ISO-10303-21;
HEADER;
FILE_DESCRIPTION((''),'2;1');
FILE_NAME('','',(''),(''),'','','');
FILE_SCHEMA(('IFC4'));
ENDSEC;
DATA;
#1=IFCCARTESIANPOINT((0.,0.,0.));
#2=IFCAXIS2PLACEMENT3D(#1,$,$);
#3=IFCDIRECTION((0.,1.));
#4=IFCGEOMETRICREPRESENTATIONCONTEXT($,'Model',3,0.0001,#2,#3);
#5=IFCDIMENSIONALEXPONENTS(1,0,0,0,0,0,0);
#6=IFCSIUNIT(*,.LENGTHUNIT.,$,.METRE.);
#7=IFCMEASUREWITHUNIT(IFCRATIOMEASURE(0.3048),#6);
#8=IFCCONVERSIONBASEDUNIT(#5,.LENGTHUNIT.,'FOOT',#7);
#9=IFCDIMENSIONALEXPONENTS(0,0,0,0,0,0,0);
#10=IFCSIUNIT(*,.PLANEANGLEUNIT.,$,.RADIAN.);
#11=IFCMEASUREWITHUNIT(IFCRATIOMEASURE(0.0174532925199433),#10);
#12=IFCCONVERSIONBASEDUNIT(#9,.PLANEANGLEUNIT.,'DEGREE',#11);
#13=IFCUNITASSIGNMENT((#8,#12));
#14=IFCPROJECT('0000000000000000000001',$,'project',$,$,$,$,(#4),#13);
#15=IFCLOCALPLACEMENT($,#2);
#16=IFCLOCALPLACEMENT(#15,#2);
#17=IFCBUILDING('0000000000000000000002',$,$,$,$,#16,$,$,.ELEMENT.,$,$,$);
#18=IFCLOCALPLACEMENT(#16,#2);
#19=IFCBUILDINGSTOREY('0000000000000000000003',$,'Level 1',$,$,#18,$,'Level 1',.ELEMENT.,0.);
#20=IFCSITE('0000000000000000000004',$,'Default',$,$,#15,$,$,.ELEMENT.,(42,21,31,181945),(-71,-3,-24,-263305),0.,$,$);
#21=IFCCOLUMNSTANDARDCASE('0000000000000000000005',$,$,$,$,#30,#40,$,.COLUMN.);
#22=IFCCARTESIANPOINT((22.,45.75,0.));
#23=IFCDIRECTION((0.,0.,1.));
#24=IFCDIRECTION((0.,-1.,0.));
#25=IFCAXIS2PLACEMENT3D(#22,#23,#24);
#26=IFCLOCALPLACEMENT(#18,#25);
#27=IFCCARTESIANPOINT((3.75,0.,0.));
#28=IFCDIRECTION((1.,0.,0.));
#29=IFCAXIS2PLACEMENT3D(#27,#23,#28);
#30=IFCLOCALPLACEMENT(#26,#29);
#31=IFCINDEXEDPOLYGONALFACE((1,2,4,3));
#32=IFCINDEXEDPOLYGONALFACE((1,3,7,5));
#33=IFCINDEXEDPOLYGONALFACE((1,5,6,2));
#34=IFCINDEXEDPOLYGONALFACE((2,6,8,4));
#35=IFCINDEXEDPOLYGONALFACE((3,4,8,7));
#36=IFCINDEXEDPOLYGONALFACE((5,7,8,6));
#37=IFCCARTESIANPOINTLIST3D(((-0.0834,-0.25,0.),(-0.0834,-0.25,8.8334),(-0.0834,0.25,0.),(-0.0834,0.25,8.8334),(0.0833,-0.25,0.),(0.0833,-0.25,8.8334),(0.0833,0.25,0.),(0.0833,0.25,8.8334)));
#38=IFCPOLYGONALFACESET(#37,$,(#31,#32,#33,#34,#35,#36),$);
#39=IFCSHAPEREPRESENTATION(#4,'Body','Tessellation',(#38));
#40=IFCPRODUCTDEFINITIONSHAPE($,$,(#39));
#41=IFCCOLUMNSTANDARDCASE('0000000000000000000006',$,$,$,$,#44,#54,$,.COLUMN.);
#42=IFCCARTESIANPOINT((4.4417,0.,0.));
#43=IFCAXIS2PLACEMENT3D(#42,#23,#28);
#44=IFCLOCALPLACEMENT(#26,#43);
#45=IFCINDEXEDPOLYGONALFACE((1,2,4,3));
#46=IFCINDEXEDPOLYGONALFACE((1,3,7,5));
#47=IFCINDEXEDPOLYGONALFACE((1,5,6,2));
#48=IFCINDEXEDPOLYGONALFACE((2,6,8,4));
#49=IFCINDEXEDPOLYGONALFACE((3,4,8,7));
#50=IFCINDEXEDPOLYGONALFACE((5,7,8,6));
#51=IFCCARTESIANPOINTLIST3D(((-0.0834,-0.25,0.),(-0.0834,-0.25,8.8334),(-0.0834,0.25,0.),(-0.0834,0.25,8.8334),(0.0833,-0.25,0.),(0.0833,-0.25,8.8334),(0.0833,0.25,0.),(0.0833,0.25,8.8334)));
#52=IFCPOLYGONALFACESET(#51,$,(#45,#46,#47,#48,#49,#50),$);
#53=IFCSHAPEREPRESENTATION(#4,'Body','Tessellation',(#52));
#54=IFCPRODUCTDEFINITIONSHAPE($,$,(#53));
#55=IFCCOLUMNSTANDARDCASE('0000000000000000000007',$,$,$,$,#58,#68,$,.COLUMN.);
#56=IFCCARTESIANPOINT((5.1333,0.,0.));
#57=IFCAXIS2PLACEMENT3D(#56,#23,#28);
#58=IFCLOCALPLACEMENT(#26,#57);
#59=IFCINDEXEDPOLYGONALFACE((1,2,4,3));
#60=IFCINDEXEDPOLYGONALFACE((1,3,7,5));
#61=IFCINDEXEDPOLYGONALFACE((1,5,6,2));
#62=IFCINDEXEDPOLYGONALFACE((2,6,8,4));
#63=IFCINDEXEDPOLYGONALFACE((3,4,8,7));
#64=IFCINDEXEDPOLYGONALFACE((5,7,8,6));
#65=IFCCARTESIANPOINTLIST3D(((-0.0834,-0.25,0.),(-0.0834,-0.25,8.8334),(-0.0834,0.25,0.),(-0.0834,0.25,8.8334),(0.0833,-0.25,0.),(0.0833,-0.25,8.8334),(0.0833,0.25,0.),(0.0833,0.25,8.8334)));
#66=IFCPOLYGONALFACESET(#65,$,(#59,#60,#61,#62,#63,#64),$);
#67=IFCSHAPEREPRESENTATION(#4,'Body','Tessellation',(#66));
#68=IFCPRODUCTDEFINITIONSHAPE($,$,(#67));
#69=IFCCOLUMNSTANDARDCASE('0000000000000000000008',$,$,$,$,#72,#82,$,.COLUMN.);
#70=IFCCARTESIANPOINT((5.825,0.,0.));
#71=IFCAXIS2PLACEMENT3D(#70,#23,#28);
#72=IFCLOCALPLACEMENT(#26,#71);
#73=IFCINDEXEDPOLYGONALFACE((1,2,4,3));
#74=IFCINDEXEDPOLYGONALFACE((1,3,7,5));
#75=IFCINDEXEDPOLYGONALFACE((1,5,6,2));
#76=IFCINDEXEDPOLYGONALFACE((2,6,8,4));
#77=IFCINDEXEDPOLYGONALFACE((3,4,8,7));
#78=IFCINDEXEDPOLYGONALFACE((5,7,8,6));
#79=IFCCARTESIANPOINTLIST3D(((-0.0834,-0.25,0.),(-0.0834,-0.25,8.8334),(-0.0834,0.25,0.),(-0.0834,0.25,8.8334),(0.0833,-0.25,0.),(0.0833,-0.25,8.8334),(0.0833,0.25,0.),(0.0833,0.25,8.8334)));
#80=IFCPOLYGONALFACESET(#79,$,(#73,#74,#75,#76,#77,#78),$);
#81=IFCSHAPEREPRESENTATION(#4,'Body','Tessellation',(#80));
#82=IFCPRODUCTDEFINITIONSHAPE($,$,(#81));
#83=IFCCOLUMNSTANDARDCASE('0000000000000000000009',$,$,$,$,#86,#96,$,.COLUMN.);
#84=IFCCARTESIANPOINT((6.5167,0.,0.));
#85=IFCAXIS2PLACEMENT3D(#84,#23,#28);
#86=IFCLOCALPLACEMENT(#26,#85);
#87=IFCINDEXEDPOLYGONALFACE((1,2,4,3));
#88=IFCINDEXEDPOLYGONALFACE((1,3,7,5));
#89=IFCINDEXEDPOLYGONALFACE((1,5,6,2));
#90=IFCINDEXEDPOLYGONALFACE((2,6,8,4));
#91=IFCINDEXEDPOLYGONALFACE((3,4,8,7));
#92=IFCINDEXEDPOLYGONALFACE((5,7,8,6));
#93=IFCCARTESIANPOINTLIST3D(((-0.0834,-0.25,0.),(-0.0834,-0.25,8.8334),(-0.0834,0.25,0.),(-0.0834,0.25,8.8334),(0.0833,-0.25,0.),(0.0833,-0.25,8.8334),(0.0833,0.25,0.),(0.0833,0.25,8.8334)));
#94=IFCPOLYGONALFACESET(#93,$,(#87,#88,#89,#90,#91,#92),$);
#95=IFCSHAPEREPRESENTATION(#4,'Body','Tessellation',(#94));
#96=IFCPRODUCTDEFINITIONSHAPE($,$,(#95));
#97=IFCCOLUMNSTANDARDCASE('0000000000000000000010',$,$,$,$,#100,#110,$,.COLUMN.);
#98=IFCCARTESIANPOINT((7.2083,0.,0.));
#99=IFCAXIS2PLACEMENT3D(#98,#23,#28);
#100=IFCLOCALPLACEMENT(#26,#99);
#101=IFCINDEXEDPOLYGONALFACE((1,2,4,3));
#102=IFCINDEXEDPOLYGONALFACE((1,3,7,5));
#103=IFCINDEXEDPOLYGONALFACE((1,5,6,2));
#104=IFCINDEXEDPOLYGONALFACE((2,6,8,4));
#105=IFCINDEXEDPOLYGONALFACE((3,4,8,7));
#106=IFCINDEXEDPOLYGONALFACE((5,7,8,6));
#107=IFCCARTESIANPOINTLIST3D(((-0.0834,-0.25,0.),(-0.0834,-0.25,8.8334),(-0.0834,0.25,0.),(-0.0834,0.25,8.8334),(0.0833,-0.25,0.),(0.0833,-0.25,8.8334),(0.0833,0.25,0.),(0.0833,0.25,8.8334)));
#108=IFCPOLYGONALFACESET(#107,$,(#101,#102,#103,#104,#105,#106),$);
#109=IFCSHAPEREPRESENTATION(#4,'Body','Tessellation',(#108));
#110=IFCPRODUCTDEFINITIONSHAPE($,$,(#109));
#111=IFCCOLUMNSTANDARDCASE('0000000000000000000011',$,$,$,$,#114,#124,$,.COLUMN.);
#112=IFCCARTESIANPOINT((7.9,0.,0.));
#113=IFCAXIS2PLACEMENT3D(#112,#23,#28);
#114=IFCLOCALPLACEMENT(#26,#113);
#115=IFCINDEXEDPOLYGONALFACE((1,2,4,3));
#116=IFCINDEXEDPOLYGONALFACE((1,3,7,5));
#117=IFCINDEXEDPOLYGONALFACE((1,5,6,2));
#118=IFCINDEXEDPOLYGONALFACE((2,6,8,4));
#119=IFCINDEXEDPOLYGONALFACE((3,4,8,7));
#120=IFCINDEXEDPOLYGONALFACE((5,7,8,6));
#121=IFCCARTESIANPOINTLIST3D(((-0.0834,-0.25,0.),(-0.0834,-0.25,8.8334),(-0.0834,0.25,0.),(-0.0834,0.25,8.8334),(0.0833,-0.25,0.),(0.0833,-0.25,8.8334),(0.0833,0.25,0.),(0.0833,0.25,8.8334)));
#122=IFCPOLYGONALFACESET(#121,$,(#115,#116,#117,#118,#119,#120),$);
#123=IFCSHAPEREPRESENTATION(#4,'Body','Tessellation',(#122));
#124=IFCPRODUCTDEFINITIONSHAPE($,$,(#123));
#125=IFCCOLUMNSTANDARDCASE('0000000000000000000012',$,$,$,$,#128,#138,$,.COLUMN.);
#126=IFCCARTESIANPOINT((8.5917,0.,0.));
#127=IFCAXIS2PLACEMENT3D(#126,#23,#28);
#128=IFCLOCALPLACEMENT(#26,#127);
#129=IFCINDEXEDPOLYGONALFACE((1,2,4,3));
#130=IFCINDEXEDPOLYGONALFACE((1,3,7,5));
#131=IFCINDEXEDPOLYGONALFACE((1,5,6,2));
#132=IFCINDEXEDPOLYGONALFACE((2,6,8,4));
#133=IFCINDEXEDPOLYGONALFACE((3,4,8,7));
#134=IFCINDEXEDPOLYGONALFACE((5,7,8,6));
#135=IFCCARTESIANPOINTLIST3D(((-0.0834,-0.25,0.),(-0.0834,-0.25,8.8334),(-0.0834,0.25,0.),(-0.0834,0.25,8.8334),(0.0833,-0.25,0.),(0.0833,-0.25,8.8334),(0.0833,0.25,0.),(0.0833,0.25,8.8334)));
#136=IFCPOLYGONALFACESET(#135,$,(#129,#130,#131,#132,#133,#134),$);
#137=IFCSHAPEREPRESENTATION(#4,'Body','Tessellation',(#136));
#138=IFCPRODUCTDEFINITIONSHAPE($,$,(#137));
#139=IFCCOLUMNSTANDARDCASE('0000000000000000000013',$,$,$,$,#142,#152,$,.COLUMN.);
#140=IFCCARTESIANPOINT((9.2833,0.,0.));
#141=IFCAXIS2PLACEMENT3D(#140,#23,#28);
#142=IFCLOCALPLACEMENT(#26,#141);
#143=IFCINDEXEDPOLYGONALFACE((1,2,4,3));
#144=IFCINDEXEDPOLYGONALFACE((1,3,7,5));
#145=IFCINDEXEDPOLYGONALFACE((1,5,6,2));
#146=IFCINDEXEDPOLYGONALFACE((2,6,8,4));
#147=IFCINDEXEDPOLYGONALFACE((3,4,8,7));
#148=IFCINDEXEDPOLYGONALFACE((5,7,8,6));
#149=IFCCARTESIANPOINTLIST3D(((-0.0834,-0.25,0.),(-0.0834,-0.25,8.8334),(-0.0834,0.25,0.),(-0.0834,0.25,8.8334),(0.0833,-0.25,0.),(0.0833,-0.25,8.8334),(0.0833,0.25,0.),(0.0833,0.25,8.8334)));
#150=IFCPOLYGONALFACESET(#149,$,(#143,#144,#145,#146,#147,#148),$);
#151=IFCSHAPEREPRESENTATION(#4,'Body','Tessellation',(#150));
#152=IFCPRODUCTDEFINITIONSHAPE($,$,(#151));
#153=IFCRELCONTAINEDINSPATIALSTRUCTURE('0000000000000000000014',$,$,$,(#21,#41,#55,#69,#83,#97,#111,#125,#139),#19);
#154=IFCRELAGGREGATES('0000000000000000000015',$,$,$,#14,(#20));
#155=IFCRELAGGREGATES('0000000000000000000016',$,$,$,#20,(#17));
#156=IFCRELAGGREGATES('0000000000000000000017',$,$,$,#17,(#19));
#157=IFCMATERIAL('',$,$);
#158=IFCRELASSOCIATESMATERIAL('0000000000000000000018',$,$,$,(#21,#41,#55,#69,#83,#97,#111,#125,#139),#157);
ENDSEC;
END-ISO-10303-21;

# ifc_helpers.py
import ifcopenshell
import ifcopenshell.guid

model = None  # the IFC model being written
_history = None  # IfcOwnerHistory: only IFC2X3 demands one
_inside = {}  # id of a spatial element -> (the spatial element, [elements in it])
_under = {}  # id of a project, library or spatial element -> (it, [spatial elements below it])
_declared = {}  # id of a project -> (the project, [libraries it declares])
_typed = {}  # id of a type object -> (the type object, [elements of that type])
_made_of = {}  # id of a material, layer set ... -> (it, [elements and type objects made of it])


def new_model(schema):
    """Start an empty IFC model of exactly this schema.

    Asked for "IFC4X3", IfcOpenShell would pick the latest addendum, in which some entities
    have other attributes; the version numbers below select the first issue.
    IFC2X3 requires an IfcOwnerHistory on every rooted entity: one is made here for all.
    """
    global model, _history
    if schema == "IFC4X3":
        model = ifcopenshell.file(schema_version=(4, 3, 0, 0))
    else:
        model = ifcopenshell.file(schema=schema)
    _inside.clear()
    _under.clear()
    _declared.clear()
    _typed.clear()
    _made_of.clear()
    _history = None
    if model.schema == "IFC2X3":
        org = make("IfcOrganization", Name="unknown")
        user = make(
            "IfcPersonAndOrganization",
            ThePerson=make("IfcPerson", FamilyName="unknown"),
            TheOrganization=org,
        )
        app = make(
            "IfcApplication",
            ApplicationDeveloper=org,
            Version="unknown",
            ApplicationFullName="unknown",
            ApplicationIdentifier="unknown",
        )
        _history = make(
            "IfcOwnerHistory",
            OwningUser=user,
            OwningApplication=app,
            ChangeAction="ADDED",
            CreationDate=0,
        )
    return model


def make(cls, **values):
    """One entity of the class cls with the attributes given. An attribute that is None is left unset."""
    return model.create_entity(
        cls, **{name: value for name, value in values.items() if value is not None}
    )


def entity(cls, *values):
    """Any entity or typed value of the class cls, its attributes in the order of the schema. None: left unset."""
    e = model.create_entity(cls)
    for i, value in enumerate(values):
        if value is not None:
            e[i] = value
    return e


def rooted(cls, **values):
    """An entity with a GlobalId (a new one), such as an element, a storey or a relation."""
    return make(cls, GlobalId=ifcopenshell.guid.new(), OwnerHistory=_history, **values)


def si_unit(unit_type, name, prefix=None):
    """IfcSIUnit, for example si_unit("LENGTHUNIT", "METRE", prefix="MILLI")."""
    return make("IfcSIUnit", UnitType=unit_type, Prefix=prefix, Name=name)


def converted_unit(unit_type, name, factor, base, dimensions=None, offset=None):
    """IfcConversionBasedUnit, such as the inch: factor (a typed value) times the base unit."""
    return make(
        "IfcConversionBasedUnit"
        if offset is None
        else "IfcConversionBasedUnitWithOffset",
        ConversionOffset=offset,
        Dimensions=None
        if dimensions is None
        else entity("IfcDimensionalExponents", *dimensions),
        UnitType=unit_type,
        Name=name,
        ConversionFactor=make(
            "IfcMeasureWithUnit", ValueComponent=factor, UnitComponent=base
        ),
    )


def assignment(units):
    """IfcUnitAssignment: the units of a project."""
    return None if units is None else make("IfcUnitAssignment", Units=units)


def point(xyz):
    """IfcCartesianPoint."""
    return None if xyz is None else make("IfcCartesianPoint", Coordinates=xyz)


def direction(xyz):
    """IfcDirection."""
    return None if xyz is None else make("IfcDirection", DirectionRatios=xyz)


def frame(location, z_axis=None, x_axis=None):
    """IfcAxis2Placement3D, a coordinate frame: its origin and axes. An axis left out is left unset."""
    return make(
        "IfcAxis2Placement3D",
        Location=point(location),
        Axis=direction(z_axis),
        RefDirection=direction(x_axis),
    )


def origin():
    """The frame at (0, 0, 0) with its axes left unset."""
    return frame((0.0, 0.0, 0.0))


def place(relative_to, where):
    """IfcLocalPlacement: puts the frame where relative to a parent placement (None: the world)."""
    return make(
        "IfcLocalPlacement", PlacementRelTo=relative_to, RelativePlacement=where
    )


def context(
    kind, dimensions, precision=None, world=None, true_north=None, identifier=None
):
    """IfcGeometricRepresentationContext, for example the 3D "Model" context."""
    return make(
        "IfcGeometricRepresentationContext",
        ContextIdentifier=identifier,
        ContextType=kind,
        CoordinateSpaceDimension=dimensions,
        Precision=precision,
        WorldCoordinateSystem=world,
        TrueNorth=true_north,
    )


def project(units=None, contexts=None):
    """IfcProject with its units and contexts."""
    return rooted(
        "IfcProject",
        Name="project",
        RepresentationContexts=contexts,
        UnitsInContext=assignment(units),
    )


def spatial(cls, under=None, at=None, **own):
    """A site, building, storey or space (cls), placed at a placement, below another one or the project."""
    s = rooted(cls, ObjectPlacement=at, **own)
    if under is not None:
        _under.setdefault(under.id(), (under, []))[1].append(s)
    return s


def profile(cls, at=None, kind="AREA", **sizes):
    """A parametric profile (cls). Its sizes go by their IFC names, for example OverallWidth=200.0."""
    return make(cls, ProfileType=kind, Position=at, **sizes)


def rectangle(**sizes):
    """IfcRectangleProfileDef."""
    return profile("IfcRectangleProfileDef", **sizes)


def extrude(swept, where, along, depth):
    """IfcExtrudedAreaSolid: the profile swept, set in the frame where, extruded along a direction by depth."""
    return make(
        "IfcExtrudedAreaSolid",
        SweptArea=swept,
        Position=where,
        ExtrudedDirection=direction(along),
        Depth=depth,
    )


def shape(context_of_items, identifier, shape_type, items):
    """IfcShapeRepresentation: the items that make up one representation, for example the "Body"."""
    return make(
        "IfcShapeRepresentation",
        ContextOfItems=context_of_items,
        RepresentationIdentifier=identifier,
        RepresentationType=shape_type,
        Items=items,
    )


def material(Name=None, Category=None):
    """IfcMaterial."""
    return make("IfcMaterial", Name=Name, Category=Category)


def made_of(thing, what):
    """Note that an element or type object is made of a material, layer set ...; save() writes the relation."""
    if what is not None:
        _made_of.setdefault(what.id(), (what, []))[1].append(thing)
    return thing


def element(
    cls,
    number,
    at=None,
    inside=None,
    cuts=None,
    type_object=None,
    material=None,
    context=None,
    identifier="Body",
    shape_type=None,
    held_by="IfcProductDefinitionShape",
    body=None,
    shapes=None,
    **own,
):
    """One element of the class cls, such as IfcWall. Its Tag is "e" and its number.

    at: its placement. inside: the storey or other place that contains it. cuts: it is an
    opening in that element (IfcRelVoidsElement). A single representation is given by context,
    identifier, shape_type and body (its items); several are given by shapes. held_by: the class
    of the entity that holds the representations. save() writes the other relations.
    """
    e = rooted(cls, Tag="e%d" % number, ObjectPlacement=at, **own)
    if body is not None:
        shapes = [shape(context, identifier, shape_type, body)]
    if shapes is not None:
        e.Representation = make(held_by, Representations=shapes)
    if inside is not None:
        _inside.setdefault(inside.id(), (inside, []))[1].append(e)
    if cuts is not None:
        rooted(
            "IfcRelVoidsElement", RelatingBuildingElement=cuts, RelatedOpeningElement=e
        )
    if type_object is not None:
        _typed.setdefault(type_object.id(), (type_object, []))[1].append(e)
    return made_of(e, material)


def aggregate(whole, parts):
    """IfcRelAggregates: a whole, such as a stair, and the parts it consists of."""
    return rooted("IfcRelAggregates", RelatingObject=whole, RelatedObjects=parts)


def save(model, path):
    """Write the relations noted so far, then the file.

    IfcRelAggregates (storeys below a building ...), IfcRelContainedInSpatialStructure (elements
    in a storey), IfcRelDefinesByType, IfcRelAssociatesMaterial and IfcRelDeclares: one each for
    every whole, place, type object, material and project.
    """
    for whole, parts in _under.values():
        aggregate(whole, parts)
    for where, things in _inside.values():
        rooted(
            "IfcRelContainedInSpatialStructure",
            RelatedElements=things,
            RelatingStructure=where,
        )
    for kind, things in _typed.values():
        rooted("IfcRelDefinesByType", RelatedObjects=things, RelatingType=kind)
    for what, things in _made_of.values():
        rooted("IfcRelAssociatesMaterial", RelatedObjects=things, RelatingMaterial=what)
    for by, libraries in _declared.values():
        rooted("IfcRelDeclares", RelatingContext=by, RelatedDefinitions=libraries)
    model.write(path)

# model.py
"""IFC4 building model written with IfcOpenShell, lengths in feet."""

from ifc_helpers import new_model, entity, si_unit, converted_unit, direction, frame, origin, place, context, project, spatial, rectangle, extrude, material, element, save


model = new_model("IFC4")

# Units and contexts
model_context = context("Model", 3, precision=0.0001, world=origin(), true_north=direction((0.0, 1.0)))
ifc_project = project(units=[converted_unit("LENGTHUNIT", "FOOT", entity("IfcRatioMeasure", 0.3048), si_unit("LENGTHUNIT", "METRE"), dimensions=[1, 0, 0, 0, 0, 0, 0]), converted_unit("PLANEANGLEUNIT", "DEGREE", entity("IfcRatioMeasure", 0.0174532925199433), si_unit("PLANEANGLEUNIT", "RADIAN"), dimensions=[0, 0, 0, 0, 0, 0, 0])], contexts=[model_context])

# Site, building, storey
site_placement = place(None, origin())
site = spatial("IfcSite", under=ifc_project, at=site_placement, Name="Default", CompositionType="ELEMENT", RefLatitude=(42, 21, 31, 181945), RefLongitude=(-71, -3, -24, -263305), RefElevation=0.0)
building_placement = place(site_placement, origin())
building = spatial("IfcBuilding", under=site, at=building_placement, CompositionType="ELEMENT")
storey_placement = place(building_placement, origin())
storey = spatial("IfcBuildingStorey", under=building, at=storey_placement, Name="Level 1", LongName="Level 1", CompositionType="ELEMENT", Elevation=0.0)

# Columns
ifc_material_1 = material(Name="")
placement_1 = place(storey_placement, frame((22.0, 45.75, 0.0), z_axis=(0.0, 0.0, 1.0), x_axis=(0.0, -1.0, 0.0)))
for number, where, z_axis, x_axis in (
    (1, (3.75, 0.0, 0.0), (0.0, 0.0, 1.0), (1.0, 0.0, 0.0)),
    (2, (4.4417, 0.0, 0.0), (0.0, 0.0, 1.0), (1.0, 0.0, 0.0)),
    (3, (5.1333, 0.0, 0.0), (0.0, 0.0, 1.0), (1.0, 0.0, 0.0)),
    (4, (5.825, 0.0, 0.0), (0.0, 0.0, 1.0), (1.0, 0.0, 0.0)),
    (5, (6.5167, 0.0, 0.0), (0.0, 0.0, 1.0), (1.0, 0.0, 0.0)),
    (6, (7.2083, 0.0, 0.0), (0.0, 0.0, 1.0), (1.0, 0.0, 0.0)),
    (7, (7.9, 0.0, 0.0), (0.0, 0.0, 1.0), (1.0, 0.0, 0.0)),
    (8, (8.5917, 0.0, 0.0), (0.0, 0.0, 1.0), (1.0, 0.0, 0.0)),
    (9, (9.2833, 0.0, 0.0), (0.0, 0.0, 1.0), (1.0, 0.0, 0.0)),
):
    element("IfcColumnStandardCase", number, at=place(placement_1, frame(where, z_axis=z_axis, x_axis=x_axis)), inside=storey, material=ifc_material_1, PredefinedType="COLUMN", context=model_context, shape_type="SweptSolid", body=[
        extrude(rectangle(XDim=0.1667, YDim=0.5), origin(), (0.0, 0.0, 1.0), 8.8334),
    ])

save(model, "model.ifc")
